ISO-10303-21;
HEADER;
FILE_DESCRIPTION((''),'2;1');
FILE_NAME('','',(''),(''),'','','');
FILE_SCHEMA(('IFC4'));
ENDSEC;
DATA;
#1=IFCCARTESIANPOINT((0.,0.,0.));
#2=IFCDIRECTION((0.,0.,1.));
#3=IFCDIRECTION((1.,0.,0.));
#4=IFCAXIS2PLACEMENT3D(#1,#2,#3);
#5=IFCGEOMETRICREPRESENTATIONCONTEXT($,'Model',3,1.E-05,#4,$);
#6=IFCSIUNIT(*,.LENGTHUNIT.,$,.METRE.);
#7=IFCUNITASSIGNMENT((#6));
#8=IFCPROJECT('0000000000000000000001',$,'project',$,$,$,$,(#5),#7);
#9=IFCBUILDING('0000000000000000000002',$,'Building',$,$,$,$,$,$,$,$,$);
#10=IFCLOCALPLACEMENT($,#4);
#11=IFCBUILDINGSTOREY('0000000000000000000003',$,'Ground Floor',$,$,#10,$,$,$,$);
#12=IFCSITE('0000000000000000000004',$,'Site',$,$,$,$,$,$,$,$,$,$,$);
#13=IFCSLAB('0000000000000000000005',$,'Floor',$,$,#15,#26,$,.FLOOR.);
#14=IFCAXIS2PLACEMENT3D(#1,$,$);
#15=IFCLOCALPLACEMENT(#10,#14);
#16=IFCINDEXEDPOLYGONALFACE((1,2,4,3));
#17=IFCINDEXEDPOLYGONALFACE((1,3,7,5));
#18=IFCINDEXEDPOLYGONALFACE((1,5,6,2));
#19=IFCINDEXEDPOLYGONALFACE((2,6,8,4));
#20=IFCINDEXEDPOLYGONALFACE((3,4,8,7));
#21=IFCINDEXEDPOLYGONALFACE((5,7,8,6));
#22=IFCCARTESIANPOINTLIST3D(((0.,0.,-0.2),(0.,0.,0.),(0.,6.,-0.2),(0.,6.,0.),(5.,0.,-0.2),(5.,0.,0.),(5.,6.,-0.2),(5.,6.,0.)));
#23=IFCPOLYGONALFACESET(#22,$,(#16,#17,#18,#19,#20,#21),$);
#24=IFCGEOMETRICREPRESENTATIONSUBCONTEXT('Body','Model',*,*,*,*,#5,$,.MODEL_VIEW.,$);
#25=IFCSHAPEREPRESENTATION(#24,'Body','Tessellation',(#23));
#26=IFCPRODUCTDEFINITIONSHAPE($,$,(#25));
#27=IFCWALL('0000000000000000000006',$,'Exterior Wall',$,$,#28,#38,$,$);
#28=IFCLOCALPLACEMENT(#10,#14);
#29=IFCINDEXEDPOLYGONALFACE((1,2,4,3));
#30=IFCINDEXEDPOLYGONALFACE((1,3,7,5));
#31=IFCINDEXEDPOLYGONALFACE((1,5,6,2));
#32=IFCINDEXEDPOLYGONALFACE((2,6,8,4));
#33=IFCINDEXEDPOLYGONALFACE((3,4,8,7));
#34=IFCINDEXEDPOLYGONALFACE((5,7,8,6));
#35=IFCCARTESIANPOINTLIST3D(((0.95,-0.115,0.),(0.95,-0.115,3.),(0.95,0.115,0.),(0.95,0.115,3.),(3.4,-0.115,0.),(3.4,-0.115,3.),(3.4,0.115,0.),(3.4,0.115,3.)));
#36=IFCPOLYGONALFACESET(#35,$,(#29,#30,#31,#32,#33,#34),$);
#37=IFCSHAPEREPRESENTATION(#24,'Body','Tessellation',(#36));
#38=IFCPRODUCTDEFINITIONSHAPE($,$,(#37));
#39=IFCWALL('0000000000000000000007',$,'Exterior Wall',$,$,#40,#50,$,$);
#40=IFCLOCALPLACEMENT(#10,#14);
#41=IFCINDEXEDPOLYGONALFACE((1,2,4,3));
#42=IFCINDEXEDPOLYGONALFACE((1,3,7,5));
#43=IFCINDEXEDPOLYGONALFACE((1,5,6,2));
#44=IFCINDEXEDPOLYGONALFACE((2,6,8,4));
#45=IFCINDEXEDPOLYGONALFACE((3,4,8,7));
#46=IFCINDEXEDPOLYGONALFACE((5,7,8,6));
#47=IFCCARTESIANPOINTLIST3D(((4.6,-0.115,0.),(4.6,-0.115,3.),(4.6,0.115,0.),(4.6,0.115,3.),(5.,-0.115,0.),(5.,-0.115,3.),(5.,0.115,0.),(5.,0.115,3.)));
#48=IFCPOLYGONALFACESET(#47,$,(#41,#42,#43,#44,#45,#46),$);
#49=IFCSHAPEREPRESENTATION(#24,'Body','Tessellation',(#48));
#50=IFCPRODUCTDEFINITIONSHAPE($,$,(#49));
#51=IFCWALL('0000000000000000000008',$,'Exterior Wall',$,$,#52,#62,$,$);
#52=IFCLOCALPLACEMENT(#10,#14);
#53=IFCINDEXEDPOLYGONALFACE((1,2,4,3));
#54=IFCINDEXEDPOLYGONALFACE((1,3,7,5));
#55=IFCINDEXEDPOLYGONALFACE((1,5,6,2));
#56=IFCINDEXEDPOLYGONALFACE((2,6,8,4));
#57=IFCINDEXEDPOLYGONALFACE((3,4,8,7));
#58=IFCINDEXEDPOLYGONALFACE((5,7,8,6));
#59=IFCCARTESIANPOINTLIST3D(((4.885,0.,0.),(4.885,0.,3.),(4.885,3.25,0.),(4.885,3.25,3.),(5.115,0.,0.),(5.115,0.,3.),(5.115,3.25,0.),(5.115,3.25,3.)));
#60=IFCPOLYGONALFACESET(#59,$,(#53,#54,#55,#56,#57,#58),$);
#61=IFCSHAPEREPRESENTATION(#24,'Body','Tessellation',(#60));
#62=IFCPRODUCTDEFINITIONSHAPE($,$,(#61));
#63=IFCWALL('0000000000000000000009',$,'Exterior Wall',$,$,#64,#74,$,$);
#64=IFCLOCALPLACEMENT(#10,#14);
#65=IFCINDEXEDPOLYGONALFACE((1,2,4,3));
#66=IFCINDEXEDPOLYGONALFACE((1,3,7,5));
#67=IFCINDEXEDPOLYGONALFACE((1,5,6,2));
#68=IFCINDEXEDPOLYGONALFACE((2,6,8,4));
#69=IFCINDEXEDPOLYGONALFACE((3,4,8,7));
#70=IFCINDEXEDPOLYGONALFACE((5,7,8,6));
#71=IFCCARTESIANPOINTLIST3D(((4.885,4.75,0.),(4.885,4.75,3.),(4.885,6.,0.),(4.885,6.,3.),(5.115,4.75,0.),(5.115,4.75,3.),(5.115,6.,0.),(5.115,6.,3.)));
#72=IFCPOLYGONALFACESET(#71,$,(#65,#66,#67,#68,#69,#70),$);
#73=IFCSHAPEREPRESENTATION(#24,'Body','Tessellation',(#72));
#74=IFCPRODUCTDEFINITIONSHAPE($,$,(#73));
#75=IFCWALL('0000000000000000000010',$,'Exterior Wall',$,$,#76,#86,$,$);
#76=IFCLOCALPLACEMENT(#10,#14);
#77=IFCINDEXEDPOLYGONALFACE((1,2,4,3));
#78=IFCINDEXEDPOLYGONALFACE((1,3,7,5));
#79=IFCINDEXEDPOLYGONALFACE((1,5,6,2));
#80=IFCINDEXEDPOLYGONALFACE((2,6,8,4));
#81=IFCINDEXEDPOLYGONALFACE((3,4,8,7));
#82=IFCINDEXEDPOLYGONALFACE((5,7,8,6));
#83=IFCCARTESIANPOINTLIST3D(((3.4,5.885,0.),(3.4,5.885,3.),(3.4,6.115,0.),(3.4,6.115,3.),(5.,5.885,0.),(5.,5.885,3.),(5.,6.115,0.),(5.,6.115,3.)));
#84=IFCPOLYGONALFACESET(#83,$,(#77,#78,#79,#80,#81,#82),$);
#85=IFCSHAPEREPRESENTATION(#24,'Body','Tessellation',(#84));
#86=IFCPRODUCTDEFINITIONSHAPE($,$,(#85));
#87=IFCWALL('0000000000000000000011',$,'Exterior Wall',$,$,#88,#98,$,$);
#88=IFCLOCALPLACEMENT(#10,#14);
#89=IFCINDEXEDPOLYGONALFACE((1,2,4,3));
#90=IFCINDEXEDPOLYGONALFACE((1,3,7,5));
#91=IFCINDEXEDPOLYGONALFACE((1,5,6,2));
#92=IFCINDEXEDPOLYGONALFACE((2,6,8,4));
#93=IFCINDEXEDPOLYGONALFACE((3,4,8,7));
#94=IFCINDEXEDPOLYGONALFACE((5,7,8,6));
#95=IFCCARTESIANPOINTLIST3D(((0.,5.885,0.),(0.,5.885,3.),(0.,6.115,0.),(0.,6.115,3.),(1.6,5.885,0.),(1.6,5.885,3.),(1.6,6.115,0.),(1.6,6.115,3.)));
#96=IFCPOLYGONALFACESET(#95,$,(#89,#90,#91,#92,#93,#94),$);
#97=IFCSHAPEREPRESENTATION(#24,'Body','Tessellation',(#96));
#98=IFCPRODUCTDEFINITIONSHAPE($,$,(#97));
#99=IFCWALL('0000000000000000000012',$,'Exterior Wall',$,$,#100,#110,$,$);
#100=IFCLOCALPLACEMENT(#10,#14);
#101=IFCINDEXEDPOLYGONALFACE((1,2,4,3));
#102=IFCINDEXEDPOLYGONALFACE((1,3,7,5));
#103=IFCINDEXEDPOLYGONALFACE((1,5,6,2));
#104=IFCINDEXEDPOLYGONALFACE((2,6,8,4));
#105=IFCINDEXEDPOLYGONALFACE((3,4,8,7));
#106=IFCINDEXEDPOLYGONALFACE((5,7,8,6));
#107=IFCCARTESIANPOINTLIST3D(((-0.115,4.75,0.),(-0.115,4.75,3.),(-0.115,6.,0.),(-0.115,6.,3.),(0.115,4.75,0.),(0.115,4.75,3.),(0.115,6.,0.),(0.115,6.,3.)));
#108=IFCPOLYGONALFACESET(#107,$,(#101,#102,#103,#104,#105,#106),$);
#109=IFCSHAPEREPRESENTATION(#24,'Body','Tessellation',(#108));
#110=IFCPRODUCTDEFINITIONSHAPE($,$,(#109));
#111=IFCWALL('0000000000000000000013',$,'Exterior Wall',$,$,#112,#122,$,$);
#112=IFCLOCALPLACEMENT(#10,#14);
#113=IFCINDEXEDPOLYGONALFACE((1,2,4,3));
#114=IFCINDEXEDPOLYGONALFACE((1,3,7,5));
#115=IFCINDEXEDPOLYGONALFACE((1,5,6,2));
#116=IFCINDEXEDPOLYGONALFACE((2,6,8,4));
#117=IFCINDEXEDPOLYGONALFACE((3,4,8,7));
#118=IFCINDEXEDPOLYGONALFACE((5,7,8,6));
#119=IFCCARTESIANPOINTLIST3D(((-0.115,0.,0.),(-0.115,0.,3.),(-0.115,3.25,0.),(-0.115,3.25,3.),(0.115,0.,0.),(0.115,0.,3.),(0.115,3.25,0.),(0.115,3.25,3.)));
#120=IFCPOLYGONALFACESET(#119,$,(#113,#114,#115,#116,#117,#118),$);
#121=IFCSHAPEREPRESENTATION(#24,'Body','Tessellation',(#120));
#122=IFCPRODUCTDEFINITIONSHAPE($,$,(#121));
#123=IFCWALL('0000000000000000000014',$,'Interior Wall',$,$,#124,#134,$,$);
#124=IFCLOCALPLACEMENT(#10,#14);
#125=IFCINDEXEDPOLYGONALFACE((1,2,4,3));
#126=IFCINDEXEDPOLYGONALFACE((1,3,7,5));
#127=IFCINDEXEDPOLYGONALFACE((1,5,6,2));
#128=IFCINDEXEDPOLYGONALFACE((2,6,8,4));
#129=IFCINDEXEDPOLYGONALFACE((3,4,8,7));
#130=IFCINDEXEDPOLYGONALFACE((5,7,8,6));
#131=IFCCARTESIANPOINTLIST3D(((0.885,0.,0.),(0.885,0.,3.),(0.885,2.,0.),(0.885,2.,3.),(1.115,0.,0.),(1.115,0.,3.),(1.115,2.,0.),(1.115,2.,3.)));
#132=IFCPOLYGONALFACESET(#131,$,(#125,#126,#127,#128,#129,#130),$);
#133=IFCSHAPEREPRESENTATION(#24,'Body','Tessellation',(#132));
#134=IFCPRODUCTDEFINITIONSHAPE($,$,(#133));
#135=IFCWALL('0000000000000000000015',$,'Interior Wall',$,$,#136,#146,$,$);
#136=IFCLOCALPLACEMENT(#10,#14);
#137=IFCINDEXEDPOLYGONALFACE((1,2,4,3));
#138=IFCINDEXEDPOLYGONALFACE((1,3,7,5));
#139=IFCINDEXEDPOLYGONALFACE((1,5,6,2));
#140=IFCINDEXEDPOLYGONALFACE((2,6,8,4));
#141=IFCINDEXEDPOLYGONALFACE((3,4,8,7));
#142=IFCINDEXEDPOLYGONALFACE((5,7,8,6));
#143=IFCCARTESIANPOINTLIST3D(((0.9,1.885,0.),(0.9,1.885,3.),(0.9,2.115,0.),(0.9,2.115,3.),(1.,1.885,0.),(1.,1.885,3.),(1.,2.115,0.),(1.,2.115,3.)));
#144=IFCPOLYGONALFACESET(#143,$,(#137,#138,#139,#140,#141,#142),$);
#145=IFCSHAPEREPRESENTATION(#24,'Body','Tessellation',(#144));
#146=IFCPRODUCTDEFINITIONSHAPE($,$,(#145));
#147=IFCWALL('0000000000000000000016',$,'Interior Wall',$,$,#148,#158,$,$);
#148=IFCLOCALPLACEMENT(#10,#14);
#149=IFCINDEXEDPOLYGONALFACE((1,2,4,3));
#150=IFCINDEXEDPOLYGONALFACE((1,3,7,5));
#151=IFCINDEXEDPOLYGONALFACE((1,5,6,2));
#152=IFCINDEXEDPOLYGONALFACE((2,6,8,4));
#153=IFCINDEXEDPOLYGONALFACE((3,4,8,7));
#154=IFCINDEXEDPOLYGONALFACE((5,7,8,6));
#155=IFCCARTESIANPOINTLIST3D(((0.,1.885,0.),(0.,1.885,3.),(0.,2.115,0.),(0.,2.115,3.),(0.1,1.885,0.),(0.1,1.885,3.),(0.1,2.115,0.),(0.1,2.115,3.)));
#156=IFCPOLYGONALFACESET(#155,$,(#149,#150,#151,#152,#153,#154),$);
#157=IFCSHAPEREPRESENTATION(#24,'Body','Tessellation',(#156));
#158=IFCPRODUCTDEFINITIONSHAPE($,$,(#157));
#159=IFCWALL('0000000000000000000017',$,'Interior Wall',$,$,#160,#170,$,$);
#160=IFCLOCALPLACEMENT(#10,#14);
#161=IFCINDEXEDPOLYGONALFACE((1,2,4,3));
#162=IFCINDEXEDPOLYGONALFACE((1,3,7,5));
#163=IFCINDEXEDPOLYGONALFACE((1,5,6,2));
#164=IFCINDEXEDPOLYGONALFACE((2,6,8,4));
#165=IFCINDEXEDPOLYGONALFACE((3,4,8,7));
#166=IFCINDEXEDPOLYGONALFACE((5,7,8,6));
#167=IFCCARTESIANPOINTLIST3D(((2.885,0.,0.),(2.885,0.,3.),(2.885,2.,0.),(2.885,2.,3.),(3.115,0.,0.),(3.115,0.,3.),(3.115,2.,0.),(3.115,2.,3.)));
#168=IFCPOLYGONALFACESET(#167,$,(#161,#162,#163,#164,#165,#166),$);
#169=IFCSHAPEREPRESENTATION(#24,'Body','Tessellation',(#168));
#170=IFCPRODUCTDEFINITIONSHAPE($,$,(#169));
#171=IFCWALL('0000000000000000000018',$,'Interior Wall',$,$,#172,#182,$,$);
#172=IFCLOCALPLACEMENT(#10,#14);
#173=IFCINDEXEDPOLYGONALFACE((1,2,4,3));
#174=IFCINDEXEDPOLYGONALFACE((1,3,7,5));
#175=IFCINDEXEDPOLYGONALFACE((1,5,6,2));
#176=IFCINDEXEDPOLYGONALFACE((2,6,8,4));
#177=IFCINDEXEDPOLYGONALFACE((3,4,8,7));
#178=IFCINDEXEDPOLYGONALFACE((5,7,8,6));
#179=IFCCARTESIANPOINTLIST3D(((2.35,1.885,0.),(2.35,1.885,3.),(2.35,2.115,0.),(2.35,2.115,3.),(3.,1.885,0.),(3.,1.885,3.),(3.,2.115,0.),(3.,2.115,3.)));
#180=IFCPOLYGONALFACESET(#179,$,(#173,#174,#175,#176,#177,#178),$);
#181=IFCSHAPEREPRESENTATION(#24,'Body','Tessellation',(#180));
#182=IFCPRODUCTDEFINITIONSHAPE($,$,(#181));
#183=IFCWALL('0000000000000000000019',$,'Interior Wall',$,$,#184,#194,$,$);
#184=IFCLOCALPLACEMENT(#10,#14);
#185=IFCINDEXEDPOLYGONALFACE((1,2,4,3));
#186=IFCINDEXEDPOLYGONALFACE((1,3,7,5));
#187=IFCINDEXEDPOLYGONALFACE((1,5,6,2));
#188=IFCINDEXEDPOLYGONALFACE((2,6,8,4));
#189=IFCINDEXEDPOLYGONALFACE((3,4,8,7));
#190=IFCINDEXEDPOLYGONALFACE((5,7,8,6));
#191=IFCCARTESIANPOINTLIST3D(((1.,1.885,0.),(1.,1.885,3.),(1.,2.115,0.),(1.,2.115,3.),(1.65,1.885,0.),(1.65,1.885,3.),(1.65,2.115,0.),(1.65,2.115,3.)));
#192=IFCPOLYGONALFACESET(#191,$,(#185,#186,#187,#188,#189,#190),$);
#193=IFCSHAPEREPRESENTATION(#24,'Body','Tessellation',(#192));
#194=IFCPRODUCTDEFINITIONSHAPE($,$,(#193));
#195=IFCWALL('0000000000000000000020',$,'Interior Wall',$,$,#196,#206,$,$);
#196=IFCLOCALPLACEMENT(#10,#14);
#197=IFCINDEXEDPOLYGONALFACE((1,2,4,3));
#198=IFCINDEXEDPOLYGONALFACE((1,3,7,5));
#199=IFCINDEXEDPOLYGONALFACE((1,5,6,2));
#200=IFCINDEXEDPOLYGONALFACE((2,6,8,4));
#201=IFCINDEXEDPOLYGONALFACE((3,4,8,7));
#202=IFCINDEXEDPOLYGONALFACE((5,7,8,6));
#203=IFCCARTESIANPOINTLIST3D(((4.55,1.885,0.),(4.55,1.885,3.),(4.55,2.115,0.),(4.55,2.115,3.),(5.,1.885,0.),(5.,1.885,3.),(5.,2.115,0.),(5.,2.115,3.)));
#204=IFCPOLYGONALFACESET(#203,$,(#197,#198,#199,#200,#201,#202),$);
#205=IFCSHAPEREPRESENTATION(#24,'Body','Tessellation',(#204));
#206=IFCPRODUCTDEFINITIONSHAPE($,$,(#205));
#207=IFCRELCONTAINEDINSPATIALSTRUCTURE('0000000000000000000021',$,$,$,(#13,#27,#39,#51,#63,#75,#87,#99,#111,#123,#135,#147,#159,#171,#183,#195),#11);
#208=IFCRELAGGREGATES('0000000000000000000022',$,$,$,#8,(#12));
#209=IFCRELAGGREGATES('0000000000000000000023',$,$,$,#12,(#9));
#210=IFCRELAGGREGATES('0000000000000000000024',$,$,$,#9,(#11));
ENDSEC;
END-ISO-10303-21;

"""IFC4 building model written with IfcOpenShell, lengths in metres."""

from ifc_helpers import new_model, si_unit, frame, origin_with_axes, place, context, subcontext, project, spatial, indexed_curve, outline, extrude, element, save


model = new_model("IFC4")

# Units and contexts
model_context = context("Model", 3, precision=1e-05, world=origin_with_axes())
body_context = subcontext(model_context, "Body", "Model", "MODEL_VIEW")
ifc_project = project(units=[si_unit("LENGTHUNIT", "METRE")], contexts=[model_context])

# Site, building, storey
site = spatial("IfcSite", under=ifc_project, Name="Site")
building = spatial("IfcBuilding", under=site, Name="Building")
storey_placement = place(None, origin_with_axes())
storey = spatial("IfcBuildingStorey", under=building, at=storey_placement, Name="Ground Floor")

# Slab
slab_placement = place(storey_placement, frame((0.0, 0.0, -0.2), z_axis=(0.0, 0.0, 1.0), x_axis=(1.0, 0.0, 0.0)))
element("IfcSlab", 1, at=slab_placement, inside=storey, Name="Floor", PredefinedType="FLOOR", context=body_context, shape_type="SweptSolid", body=[
    extrude(outline(indexed_curve([(0.0, 0.0), (5.0, 0.0), (5.0, 6.0), (0.0, 6.0)])), None, (0.0, 0.0, 1.0), 0.2),
])

# Walls
wall_1_placement = place(storey_placement, frame((0.95, 0.0, 0.0), z_axis=(0.0, 0.0, 1.0), x_axis=(1.0, 0.0, 0.0)))
element("IfcWall", 2, at=wall_1_placement, inside=storey, Name="Exterior Wall", context=body_context, shape_type="SweptSolid", body=[
    extrude(outline(indexed_curve([(0.0, 0.0), (0.0, 0.23), (2.45, 0.23), (2.45, 0.0), (0.0, 0.0)], self_intersect=False)), frame((0.0, -0.115, 0.0), z_axis=(0.0, 0.0, 1.0), x_axis=(1.0, 0.0, 0.0)), (0.0, 0.0, 1.0), 3.0),
])
wall_2_placement = place(storey_placement, frame((4.6, 0.0, 0.0), z_axis=(0.0, 0.0, 1.0), x_axis=(1.0, 0.0, 0.0)))
element("IfcWall", 3, at=wall_2_placement, inside=storey, Name="Exterior Wall", context=body_context, shape_type="SweptSolid", body=[
    extrude(outline(indexed_curve([(0.0, 0.0), (0.0, 0.23), (0.4, 0.23), (0.4, 0.0), (0.0, 0.0)], self_intersect=False)), frame((0.0, -0.115, 0.0), z_axis=(0.0, 0.0, 1.0), x_axis=(1.0, 0.0, 0.0)), (0.0, 0.0, 1.0), 3.0),
])
wall_3_placement = place(storey_placement, frame((5.0, 0.0, 0.0), z_axis=(0.0, 0.0, 1.0), x_axis=(0.0, 1.0, 0.0)))
element("IfcWall", 4, at=wall_3_placement, inside=storey, Name="Exterior Wall", context=body_context, shape_type="SweptSolid", body=[
    extrude(outline(indexed_curve([(0.0, 0.0), (0.0, 0.23), (3.25, 0.23), (3.25, 0.0), (0.0, 0.0)], self_intersect=False)), frame((0.0, -0.115, 0.0), z_axis=(0.0, 0.0, 1.0), x_axis=(1.0, 0.0, 0.0)), (0.0, 0.0, 1.0), 3.0),
])
wall_4_placement = place(storey_placement, frame((5.0, 4.75, 0.0), z_axis=(0.0, 0.0, 1.0), x_axis=(0.0, 1.0, 0.0)))
element("IfcWall", 5, at=wall_4_placement, inside=storey, Name="Exterior Wall", context=body_context, shape_type="SweptSolid", body=[
    extrude(outline(indexed_curve([(0.0, 0.0), (0.0, 0.23), (1.25, 0.23), (1.25, 0.0), (0.0, 0.0)], self_intersect=False)), frame((0.0, -0.115, 0.0), z_axis=(0.0, 0.0, 1.0), x_axis=(1.0, 0.0, 0.0)), (0.0, 0.0, 1.0), 3.0),
])
for number, where, z_axis, x_axis, name in (
    (6, (5.0, 6.0, 0.0), (0.0, 0.0, 1.0), (-1.0, 0.0, 0.0), "Exterior Wall"),
    (7, (1.6, 6.0, 0.0), (0.0, 0.0, 1.0), (-1.0, 0.0, 0.0), "Exterior Wall"),
):
    element("IfcWall", number, at=place(storey_placement, frame(where, z_axis=z_axis, x_axis=x_axis)), inside=storey, Name=name, context=body_context, shape_type="SweptSolid", body=[
        extrude(outline(indexed_curve([(0.0, 0.0), (0.0, 0.23), (1.6, 0.23), (1.6, 0.0), (0.0, 0.0)], self_intersect=False)), frame((0.0, -0.115, 0.0), z_axis=(0.0, 0.0, 1.0), x_axis=(1.0, 0.0, 0.0)), (0.0, 0.0, 1.0), 3.0),
    ])
wall_5_placement = place(storey_placement, frame((0.0, 6.0, 0.0), z_axis=(0.0, 0.0, 1.0), x_axis=(0.0, -1.0, 0.0)))
element("IfcWall", 8, at=wall_5_placement, inside=storey, Name="Exterior Wall", context=body_context, shape_type="SweptSolid", body=[
    extrude(outline(indexed_curve([(0.0, 0.0), (0.0, 0.23), (1.25, 0.23), (1.25, 0.0), (0.0, 0.0)], self_intersect=False)), frame((0.0, -0.115, 0.0), z_axis=(0.0, 0.0, 1.0), x_axis=(1.0, 0.0, 0.0)), (0.0, 0.0, 1.0), 3.0),
])
wall_6_placement = place(storey_placement, frame((0.0, 3.25, 0.0), z_axis=(0.0, 0.0, 1.0), x_axis=(0.0, -1.0, 0.0)))
element("IfcWall", 9, at=wall_6_placement, inside=storey, Name="Exterior Wall", context=body_context, shape_type="SweptSolid", body=[
    extrude(outline(indexed_curve([(0.0, 0.0), (0.0, 0.23), (3.25, 0.23), (3.25, 0.0), (0.0, 0.0)], self_intersect=False)), frame((0.0, -0.115, 0.0), z_axis=(0.0, 0.0, 1.0), x_axis=(1.0, 0.0, 0.0)), (0.0, 0.0, 1.0), 3.0),
])
wall_7_placement = place(storey_placement, frame((1.0, 0.0, 0.0), z_axis=(0.0, 0.0, 1.0), x_axis=(0.0, 1.0, 0.0)))
element("IfcWall", 10, at=wall_7_placement, inside=storey, Name="Interior Wall", context=body_context, shape_type="SweptSolid", body=[
    extrude(outline(indexed_curve([(0.0, 0.0), (0.0, 0.23), (2.0, 0.23), (2.0, 0.0), (0.0, 0.0)], self_intersect=False)), frame((0.0, -0.115, 0.0), z_axis=(0.0, 0.0, 1.0), x_axis=(1.0, 0.0, 0.0)), (0.0, 0.0, 1.0), 3.0),
])
for number, where, z_axis, x_axis, name in (
    (11, (1.0, 2.0, 0.0), (0.0, 0.0, 1.0), (-1.0, 0.0, 0.0), "Interior Wall"),
    (12, (0.1, 2.0, 0.0), (0.0, 0.0, 1.0), (-1.0, 0.0, 0.0), "Interior Wall"),
):
    element("IfcWall", number, at=place(storey_placement, frame(where, z_axis=z_axis, x_axis=x_axis)), inside=storey, Name=name, context=body_context, shape_type="SweptSolid", body=[
        extrude(outline(indexed_curve([(0.0, 0.0), (0.0, 0.23), (0.1, 0.23), (0.1, 0.0), (0.0, 0.0)], self_intersect=False)), frame((0.0, -0.115, 0.0), z_axis=(0.0, 0.0, 1.0), x_axis=(1.0, 0.0, 0.0)), (0.0, 0.0, 1.0), 3.0),
    ])
wall_8_placement = place(storey_placement, frame((3.0, 0.0, 0.0), z_axis=(0.0, 0.0, 1.0), x_axis=(0.0, 1.0, 0.0)))
element("IfcWall", 13, at=wall_8_placement, inside=storey, Name="Interior Wall", context=body_context, shape_type="SweptSolid", body=[
    extrude(outline(indexed_curve([(0.0, 0.0), (0.0, 0.23), (2.0, 0.23), (2.0, 0.0), (0.0, 0.0)], self_intersect=False)), frame((0.0, -0.115, 0.0), z_axis=(0.0, 0.0, 1.0), x_axis=(1.0, 0.0, 0.0)), (0.0, 0.0, 1.0), 3.0),
])
for number, where, z_axis, x_axis, name in (
    (14, (3.0, 2.0, 0.0), (0.0, 0.0, 1.0), (-1.0, 0.0, 0.0), "Interior Wall"),
    (15, (1.65, 2.0, 0.0), (0.0, 0.0, 1.0), (-1.0, 0.0, 0.0), "Interior Wall"),
):
    element("IfcWall", number, at=place(storey_placement, frame(where, z_axis=z_axis, x_axis=x_axis)), inside=storey, Name=name, context=body_context, shape_type="SweptSolid", body=[
        extrude(outline(indexed_curve([(0.0, 0.0), (0.0, 0.23), (0.65, 0.23), (0.65, 0.0), (0.0, 0.0)], self_intersect=False)), frame((0.0, -0.115, 0.0), z_axis=(0.0, 0.0, 1.0), x_axis=(1.0, 0.0, 0.0)), (0.0, 0.0, 1.0), 3.0),
    ])
for number, where, z_axis, x_axis, name in (
    (16, (5.0, 2.0, 0.0), (0.0, 0.0, 1.0), (-1.0, 0.0, 0.0), "Interior Wall"),
):
    element("IfcWall", number, at=place(storey_placement, frame(where, z_axis=z_axis, x_axis=x_axis)), inside=storey, Name=name, context=body_context, shape_type="SweptSolid", body=[
        extrude(outline(indexed_curve([(0.0, 0.0), (0.0, 0.23), (0.45, 0.23), (0.45, 0.0), (0.0, 0.0)], self_intersect=False)), frame((0.0, -0.115, 0.0), z_axis=(0.0, 0.0, 1.0), x_axis=(1.0, 0.0, 0.0)), (0.0, 0.0, 1.0), 3.0),
    ])

save(model, "model.ifc")
